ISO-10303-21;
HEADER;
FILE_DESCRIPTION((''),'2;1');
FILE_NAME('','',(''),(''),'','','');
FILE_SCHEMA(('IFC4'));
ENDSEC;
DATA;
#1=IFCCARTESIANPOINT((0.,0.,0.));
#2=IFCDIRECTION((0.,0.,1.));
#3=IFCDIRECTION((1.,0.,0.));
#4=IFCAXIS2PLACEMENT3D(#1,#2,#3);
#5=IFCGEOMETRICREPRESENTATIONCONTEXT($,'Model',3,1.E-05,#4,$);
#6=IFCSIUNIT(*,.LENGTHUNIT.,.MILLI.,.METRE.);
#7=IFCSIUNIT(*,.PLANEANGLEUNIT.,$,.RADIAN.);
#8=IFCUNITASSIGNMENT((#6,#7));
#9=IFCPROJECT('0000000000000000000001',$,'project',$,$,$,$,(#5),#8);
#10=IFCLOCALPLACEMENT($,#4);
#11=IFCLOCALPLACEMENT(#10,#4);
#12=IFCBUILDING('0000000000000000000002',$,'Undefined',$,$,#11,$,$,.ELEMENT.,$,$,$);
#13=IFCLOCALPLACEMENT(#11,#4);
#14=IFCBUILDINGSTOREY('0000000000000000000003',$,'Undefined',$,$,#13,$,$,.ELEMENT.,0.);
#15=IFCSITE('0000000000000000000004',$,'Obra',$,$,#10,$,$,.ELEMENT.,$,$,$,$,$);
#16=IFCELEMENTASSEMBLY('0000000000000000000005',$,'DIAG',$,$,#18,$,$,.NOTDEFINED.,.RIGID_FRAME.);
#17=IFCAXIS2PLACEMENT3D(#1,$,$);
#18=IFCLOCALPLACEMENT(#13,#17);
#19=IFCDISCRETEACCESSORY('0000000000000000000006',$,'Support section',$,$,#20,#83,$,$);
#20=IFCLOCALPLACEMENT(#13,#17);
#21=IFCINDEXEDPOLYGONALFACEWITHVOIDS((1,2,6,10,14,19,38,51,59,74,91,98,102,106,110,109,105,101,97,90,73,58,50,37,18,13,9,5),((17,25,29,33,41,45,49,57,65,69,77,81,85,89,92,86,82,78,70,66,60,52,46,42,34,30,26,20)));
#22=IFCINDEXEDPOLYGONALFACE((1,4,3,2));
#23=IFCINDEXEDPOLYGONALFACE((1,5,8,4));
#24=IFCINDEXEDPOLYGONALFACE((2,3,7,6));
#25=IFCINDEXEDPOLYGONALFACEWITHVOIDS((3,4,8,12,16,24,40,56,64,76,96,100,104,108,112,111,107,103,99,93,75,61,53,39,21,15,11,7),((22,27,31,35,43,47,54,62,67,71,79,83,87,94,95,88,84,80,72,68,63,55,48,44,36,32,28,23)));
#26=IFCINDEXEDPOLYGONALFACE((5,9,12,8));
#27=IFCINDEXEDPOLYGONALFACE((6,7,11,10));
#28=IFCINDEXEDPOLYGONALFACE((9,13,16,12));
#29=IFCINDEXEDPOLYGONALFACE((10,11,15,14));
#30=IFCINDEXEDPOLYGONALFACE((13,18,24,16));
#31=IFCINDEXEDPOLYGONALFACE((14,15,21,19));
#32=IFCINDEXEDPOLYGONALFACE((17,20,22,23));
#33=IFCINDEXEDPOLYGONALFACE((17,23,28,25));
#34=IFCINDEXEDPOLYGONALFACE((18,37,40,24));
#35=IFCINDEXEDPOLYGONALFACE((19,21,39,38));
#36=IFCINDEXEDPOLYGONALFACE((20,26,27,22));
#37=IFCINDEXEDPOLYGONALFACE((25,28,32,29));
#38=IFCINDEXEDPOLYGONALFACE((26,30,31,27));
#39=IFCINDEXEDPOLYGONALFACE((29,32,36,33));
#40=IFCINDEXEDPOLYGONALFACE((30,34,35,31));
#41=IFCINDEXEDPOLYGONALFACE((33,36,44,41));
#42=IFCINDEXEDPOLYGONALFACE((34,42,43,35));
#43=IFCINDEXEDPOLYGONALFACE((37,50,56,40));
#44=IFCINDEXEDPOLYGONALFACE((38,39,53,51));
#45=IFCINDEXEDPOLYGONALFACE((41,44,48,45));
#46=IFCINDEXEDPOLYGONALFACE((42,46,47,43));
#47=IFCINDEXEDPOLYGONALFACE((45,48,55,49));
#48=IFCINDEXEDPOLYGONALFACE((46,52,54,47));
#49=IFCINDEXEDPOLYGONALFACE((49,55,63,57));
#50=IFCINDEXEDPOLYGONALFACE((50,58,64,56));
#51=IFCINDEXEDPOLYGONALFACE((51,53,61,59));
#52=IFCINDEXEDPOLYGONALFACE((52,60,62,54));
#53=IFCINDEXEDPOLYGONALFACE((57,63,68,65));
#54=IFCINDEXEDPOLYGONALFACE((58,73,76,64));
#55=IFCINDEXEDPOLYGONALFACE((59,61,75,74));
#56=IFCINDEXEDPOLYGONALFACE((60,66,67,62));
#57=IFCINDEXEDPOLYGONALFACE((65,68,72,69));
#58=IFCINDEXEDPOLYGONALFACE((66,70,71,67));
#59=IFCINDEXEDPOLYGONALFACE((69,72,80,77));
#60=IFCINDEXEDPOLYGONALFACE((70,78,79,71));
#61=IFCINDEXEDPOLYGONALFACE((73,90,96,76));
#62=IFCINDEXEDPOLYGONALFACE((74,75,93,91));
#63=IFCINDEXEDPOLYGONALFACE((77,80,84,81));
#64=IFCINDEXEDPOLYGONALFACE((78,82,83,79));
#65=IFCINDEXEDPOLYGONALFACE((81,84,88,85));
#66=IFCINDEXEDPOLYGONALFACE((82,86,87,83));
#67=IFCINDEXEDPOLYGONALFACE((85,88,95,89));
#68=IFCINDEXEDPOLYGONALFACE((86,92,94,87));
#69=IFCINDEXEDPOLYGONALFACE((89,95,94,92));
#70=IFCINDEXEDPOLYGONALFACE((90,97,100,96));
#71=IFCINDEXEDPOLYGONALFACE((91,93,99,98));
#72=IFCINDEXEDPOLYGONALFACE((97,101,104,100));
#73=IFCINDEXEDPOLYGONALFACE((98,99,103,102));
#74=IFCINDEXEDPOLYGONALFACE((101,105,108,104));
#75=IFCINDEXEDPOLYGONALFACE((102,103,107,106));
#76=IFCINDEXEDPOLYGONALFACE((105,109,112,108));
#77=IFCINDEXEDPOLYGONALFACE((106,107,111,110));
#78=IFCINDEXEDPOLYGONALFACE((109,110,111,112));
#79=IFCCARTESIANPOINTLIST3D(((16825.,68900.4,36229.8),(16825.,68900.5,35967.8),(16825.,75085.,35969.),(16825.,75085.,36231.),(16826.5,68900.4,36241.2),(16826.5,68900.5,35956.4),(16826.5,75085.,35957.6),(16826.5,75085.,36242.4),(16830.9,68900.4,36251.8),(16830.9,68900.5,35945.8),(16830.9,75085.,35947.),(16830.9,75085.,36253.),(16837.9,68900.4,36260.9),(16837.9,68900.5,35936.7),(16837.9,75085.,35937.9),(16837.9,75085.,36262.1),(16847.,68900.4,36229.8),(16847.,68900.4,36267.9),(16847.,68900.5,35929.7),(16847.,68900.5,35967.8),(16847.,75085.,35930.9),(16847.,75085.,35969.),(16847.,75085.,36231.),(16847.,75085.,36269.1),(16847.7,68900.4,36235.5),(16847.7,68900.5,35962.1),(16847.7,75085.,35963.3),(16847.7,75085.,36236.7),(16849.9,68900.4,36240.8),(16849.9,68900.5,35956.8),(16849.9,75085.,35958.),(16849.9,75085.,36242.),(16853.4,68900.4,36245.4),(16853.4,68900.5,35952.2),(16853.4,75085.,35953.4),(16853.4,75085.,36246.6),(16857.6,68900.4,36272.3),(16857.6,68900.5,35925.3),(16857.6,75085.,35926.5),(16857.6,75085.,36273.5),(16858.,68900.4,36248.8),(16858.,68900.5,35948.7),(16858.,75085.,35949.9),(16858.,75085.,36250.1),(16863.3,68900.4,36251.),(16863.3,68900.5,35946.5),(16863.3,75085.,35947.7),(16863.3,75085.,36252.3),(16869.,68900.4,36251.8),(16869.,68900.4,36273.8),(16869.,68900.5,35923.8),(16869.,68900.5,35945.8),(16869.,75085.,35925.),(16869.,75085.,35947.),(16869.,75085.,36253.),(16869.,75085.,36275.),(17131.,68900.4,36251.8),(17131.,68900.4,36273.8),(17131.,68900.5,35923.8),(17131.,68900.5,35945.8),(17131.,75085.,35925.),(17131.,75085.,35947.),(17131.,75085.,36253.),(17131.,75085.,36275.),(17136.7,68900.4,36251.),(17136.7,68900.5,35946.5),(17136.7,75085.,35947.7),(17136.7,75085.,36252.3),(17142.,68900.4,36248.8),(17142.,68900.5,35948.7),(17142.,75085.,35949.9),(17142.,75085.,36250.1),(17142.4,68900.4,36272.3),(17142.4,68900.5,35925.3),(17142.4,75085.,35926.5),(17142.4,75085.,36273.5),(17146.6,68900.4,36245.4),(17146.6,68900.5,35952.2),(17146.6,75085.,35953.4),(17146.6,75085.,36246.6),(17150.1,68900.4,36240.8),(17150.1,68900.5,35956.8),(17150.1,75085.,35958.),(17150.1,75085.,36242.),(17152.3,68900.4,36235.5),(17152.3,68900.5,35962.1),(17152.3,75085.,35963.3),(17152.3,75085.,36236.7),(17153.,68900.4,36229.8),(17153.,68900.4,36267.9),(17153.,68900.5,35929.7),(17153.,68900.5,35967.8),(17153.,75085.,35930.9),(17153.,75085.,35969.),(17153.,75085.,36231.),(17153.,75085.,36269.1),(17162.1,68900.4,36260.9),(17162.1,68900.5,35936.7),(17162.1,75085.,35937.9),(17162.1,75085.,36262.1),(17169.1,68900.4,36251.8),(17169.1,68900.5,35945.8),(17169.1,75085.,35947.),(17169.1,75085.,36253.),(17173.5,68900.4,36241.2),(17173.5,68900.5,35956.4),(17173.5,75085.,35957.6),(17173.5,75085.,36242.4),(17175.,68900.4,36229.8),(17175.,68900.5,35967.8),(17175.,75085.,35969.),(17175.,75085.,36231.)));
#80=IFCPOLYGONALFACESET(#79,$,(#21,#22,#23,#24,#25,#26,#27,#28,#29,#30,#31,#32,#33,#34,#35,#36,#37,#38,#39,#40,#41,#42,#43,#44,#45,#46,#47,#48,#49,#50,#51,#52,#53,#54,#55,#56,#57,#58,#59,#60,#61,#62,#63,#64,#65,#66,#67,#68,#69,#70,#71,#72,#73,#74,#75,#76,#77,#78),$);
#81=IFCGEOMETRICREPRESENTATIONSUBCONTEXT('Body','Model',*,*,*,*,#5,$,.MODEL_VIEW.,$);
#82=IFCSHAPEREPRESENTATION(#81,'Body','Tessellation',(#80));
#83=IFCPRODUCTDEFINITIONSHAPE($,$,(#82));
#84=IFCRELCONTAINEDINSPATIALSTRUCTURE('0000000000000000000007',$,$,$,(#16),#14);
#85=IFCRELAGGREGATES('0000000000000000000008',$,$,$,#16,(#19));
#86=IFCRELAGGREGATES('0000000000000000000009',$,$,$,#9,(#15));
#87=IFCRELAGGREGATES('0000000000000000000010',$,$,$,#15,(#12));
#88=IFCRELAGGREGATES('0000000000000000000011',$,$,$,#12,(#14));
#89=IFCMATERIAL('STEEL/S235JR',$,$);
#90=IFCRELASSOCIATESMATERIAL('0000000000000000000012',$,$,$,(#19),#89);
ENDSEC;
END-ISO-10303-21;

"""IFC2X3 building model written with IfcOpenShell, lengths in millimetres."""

from ifc_helpers import new_model, si_unit, frame, origin_with_axes, origin_2d_with_axis, place, context, subcontext, project, spatial, hollow_rectangle, extrude, clip, halfspace, material, element, aggregate, save


model = new_model("IFC2X3")

# Units and contexts
model_context = context("Model", 3, precision=1e-05, world=origin_with_axes())
body_context = subcontext(model_context, "Body", "Model", "MODEL_VIEW")
ifc_project = project(units=[si_unit("LENGTHUNIT", "METRE", prefix="MILLI"), si_unit("PLANEANGLEUNIT", "RADIAN")], contexts=[model_context])

# Site, building, storey
site_placement = place(None, origin_with_axes())
site = spatial("IfcSite", under=ifc_project, at=site_placement, Name="Obra", CompositionType="ELEMENT")
building_placement = place(site_placement, origin_with_axes())
building = spatial("IfcBuilding", under=site, at=building_placement, Name="Undefined", CompositionType="ELEMENT")
storey_placement = place(building_placement, origin_with_axes())
storey = spatial("IfcBuildingStorey", under=building, at=storey_placement, Name="Undefined", CompositionType="ELEMENT", Elevation=0.0)

# Element assembly
assembly_1_placement = place(storey_placement, origin_with_axes())
assembly_1 = element("IfcElementAssembly", 1, at=assembly_1_placement, inside=storey, Name="DIAG", AssemblyPlace="NOTDEFINED", PredefinedType="RIGID_FRAME")
ifc_material_1 = material(Name="STEEL/S235JR")

# Discrete accessory
discrete_accessory_1_placement = place(assembly_1_placement, frame((17000.0, 68880.6, 36098.8), z_axis=(0.0, -0.000195, 1.0), x_axis=(0.0, 1.0, 0.000195)))
discrete_accessory_1 = element("IfcDiscreteAccessory", 2, at=discrete_accessory_1_placement, material=ifc_material_1, Name="Support section", context=body_context, shape_type="Clipping", body=[
    clip(extrude(hollow_rectangle(XDim=350.0, YDim=350.0, WallThickness=22.0, InnerFilletRadius=22.0, OuterFilletRadius=44.0, at=origin_2d_with_axis()), frame((6204.4, 0.0, 0.0), z_axis=(-1.0, 0.0, 0.0), x_axis=(0.0, -1.0, 0.0)), (0.0, 0.0, 1.0), 6184.6), halfspace(frame((20.0, 0.0, -175.0), z_axis=(1.0, 0.0, -0.000097), x_axis=(0.0, -1.0, 0.0)), True)),
])
aggregate(assembly_1, [discrete_accessory_1])

save(model, "model.ifc")
